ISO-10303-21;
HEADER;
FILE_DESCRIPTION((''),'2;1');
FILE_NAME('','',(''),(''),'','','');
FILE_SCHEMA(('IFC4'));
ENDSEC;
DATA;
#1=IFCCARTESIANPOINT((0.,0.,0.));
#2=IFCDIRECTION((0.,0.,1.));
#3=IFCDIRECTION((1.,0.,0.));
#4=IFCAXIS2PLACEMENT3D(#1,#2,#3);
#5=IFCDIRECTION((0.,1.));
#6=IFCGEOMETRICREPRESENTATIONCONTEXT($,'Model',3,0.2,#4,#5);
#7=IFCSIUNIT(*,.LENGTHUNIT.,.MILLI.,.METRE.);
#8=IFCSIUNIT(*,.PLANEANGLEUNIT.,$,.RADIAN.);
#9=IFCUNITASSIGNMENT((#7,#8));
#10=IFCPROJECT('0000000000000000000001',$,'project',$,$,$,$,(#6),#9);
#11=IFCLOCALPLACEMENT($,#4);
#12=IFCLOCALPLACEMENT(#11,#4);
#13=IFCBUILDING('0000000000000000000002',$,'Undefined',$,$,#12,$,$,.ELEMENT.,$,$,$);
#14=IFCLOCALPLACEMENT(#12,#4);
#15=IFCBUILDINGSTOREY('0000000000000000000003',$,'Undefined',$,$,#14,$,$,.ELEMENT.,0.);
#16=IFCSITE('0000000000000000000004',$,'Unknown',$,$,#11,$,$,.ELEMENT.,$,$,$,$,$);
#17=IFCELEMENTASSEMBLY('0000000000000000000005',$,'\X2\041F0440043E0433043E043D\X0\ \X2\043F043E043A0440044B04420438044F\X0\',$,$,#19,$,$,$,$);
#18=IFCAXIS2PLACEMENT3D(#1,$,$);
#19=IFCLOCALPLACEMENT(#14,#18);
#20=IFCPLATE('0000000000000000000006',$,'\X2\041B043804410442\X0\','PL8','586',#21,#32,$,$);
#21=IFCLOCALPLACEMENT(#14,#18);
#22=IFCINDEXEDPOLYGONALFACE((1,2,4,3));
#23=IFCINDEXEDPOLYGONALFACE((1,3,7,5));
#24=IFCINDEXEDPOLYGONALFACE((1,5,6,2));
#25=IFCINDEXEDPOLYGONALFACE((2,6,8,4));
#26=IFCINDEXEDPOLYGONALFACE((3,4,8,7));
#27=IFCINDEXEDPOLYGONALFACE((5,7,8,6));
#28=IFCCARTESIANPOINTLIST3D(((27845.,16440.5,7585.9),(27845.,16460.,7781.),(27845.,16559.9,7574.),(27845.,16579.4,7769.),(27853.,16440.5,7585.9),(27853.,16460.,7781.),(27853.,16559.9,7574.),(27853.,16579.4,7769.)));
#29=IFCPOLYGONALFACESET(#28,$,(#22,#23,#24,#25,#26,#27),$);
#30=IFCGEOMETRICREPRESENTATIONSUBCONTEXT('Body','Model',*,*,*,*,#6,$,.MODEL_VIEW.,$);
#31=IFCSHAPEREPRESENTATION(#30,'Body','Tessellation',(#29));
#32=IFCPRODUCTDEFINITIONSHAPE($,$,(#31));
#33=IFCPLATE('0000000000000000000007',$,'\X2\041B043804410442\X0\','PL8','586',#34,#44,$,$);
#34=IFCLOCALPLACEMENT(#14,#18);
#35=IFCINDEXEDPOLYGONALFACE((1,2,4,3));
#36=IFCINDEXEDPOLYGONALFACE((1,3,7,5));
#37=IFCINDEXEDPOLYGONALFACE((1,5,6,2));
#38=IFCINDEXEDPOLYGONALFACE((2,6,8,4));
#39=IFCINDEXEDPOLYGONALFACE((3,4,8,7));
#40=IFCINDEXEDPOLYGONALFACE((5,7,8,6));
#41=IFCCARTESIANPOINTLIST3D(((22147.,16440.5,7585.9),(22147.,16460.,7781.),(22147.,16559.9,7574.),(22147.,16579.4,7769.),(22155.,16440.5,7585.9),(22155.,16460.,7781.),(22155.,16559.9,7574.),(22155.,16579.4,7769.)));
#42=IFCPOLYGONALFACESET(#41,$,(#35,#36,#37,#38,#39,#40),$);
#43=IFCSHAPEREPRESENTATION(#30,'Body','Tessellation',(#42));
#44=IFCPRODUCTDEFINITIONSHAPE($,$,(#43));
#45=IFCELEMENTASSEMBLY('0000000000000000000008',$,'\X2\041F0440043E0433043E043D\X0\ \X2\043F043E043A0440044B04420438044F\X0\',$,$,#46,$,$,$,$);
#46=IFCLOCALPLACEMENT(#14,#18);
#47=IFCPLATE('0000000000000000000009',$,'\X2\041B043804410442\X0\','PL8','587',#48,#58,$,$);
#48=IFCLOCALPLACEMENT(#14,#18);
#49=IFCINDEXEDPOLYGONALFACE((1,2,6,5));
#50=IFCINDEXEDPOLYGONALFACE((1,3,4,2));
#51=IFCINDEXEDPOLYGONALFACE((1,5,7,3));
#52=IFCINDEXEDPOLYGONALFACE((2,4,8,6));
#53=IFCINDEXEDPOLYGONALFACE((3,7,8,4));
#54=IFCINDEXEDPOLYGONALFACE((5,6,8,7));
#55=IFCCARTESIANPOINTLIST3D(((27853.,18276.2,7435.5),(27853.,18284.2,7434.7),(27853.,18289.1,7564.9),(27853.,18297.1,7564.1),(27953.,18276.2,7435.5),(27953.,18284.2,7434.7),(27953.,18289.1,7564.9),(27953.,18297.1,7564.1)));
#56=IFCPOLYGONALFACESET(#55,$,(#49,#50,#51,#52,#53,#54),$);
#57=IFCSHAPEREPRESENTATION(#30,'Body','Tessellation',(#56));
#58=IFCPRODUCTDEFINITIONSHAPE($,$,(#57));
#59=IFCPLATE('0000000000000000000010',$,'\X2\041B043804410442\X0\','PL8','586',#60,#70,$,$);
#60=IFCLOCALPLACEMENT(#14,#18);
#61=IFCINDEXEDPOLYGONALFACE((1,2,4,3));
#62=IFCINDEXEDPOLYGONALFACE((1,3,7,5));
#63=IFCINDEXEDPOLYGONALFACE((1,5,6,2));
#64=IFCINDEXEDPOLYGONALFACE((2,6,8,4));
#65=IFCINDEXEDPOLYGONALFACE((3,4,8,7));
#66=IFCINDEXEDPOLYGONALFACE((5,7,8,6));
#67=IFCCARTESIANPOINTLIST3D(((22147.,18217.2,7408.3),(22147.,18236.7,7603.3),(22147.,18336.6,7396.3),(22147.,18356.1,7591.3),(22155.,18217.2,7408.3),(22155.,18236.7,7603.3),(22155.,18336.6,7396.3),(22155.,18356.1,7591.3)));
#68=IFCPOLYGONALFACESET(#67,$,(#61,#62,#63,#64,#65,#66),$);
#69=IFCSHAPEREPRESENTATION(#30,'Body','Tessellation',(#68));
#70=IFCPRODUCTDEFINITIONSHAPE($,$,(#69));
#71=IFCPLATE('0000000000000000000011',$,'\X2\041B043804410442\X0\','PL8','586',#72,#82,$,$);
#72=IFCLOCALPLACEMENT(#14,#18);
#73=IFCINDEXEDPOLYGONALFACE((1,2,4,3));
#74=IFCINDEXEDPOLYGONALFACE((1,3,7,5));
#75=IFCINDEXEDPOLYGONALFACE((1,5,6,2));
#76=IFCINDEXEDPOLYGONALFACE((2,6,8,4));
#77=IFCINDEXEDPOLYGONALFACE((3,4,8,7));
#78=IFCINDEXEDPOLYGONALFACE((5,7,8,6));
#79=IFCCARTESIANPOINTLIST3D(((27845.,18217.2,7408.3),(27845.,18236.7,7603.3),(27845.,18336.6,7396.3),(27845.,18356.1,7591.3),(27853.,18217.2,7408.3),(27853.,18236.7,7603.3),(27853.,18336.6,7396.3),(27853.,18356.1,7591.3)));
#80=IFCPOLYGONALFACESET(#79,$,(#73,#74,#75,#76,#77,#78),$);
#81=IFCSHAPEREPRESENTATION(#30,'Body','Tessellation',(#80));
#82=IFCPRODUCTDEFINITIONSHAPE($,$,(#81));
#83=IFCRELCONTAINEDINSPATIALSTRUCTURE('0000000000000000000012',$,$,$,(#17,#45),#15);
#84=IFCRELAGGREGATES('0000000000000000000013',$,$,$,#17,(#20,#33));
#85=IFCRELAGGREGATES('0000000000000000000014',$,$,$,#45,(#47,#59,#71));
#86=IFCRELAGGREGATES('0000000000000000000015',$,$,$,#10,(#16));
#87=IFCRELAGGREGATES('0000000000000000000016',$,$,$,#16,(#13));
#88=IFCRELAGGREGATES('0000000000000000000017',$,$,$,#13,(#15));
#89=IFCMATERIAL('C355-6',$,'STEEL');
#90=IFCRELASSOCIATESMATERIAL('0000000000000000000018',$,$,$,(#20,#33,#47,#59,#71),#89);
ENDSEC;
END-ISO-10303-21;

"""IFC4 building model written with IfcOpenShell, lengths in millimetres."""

from ifc_helpers import new_model, si_unit, direction, frame, origin_with_axes, place, context, subcontext, project, spatial, line, indexed_curve, outline, extrude, material, element, aggregate, save


model = new_model("IFC4")

# Units and contexts
model_context = context("Model", 3, precision=0.2, world=origin_with_axes(), true_north=direction((0.0, 1.0)))
body_context = subcontext(model_context, "Body", "Model", "MODEL_VIEW")
ifc_project = project(units=[si_unit("LENGTHUNIT", "METRE", prefix="MILLI"), si_unit("PLANEANGLEUNIT", "RADIAN")], contexts=[model_context])

# Site, building, storey
site_placement = place(None, origin_with_axes())
site = spatial("IfcSite", under=ifc_project, at=site_placement, Name="Unknown", CompositionType="ELEMENT")
building_placement = place(site_placement, origin_with_axes())
building = spatial("IfcBuilding", under=site, at=building_placement, Name="Undefined", CompositionType="ELEMENT")
storey_placement = place(building_placement, origin_with_axes())
storey = spatial("IfcBuildingStorey", under=building, at=storey_placement, Name="Undefined", CompositionType="ELEMENT", Elevation=0.0)

# Element assemblies, plates
ifc_material_1 = material(Name="C355-6", Category="STEEL")
assembly_1_placement = place(storey_placement, frame((28000.0, 16510.0, 7677.5), z_axis=(0.0, -0.995037, 0.099504), x_axis=(-1.0, 0.0, 0.0)))
assembly_1 = element("IfcElementAssembly", 1, at=assembly_1_placement, inside=storey, Name="Прогон покрытия")
plate_1_placement = place(assembly_1_placement, frame((151.0, -98.0, -60.0), z_axis=(-1.0, 0.0, 0.0), x_axis=(0.0, 0.0, 1.0)))
plate_1 = element("IfcPlate", 2, at=plate_1_placement, material=ifc_material_1, Name="Лист", Description="PL8", ObjectType="586", context=body_context, shape_type="SolidModel", body=[
    extrude(outline(indexed_curve([(0.0, 0.0), (120.0, 0.0), (120.0, 196.0), (0.0, 196.0)], segments=[line(1, 2, 3, 4, 1)])), frame((0.0, 0.0, 4.0), z_axis=(0.0, 0.0, 1.0), x_axis=(1.0, 0.0, 0.0)), (0.0, 0.0, -1.0), 8.0),
])
plate_2_placement = place(assembly_1_placement, frame((5849.0, -98.0, 60.0), z_axis=(1.0, 0.0, 0.0), x_axis=(0.0, 0.0, -1.0)))
plate_2 = element("IfcPlate", 3, at=plate_2_placement, material=ifc_material_1, Name="Лист", Description="PL8", ObjectType="586", context=body_context, shape_type="SolidModel", body=[
    extrude(outline(indexed_curve([(0.0, 0.0), (120.0, 0.0), (120.0, 196.0), (0.0, 196.0)], segments=[line(1, 2, 3, 4, 1)])), frame((0.0, 0.0, 4.0), z_axis=(0.0, 0.0, 1.0), x_axis=(1.0, 0.0, 0.0)), (0.0, 0.0, -1.0), 8.0),
])
aggregate(assembly_1, [plate_1, plate_2])
assembly_2_placement = place(storey_placement, frame((28000.0, 18286.7, 7499.8), z_axis=(0.0, -0.995037, 0.099504), x_axis=(-1.0, 0.0, 0.0)))
assembly_2 = element("IfcElementAssembly", 4, at=assembly_2_placement, inside=storey, Name="Прогон покрытия")
plate_3_placement = place(assembly_2_placement, frame((47.0, -65.0, 0.0), z_axis=(0.0, 0.0, 1.0), x_axis=(1.0, 0.0, 0.0)))
plate_3 = element("IfcPlate", 5, at=plate_3_placement, material=ifc_material_1, Name="Лист", Description="PL8", ObjectType="587", context=body_context, shape_type="SolidModel", body=[
    extrude(outline(indexed_curve([(0.0, 0.0), (100.0, 0.0), (100.0, 130.0), (0.0, 130.0)], segments=[line(1, 2, 3, 4, 1)])), frame((0.0, 0.0, 4.0), z_axis=(0.0, 0.0, 1.0), x_axis=(1.0, 0.0, 0.0)), (0.0, 0.0, -1.0), 8.0),
])
plate_4_placement = place(assembly_2_placement, frame((5849.0, -98.0, 60.0), z_axis=(1.0, 0.0, 0.0), x_axis=(0.0, 0.0, -1.0)))
plate_4 = element("IfcPlate", 6, at=plate_4_placement, material=ifc_material_1, Name="Лист", Description="PL8", ObjectType="586", context=body_context, shape_type="SolidModel", body=[
    extrude(outline(indexed_curve([(0.0, 0.0), (120.0, 0.0), (120.0, 196.0), (0.0, 196.0)], segments=[line(1, 2, 3, 4, 1)])), frame((0.0, 0.0, 4.0), z_axis=(0.0, 0.0, 1.0), x_axis=(1.0, 0.0, 0.0)), (0.0, 0.0, -1.0), 8.0),
])
plate_5_placement = place(assembly_2_placement, frame((151.0, -98.0, -60.0), z_axis=(-1.0, 0.0, 0.0), x_axis=(0.0, 0.0, 1.0)))
plate_5 = element("IfcPlate", 7, at=plate_5_placement, material=ifc_material_1, Name="Лист", Description="PL8", ObjectType="586", context=body_context, shape_type="SolidModel", body=[
    extrude(outline(indexed_curve([(0.0, 0.0), (120.0, 0.0), (120.0, 196.0), (0.0, 196.0)], segments=[line(1, 2, 3, 4, 1)])), frame((0.0, 0.0, 4.0), z_axis=(0.0, 0.0, 1.0), x_axis=(1.0, 0.0, 0.0)), (0.0, 0.0, -1.0), 8.0),
])
aggregate(assembly_2, [plate_3, plate_4, plate_5])

save(model, "model.ifc")
